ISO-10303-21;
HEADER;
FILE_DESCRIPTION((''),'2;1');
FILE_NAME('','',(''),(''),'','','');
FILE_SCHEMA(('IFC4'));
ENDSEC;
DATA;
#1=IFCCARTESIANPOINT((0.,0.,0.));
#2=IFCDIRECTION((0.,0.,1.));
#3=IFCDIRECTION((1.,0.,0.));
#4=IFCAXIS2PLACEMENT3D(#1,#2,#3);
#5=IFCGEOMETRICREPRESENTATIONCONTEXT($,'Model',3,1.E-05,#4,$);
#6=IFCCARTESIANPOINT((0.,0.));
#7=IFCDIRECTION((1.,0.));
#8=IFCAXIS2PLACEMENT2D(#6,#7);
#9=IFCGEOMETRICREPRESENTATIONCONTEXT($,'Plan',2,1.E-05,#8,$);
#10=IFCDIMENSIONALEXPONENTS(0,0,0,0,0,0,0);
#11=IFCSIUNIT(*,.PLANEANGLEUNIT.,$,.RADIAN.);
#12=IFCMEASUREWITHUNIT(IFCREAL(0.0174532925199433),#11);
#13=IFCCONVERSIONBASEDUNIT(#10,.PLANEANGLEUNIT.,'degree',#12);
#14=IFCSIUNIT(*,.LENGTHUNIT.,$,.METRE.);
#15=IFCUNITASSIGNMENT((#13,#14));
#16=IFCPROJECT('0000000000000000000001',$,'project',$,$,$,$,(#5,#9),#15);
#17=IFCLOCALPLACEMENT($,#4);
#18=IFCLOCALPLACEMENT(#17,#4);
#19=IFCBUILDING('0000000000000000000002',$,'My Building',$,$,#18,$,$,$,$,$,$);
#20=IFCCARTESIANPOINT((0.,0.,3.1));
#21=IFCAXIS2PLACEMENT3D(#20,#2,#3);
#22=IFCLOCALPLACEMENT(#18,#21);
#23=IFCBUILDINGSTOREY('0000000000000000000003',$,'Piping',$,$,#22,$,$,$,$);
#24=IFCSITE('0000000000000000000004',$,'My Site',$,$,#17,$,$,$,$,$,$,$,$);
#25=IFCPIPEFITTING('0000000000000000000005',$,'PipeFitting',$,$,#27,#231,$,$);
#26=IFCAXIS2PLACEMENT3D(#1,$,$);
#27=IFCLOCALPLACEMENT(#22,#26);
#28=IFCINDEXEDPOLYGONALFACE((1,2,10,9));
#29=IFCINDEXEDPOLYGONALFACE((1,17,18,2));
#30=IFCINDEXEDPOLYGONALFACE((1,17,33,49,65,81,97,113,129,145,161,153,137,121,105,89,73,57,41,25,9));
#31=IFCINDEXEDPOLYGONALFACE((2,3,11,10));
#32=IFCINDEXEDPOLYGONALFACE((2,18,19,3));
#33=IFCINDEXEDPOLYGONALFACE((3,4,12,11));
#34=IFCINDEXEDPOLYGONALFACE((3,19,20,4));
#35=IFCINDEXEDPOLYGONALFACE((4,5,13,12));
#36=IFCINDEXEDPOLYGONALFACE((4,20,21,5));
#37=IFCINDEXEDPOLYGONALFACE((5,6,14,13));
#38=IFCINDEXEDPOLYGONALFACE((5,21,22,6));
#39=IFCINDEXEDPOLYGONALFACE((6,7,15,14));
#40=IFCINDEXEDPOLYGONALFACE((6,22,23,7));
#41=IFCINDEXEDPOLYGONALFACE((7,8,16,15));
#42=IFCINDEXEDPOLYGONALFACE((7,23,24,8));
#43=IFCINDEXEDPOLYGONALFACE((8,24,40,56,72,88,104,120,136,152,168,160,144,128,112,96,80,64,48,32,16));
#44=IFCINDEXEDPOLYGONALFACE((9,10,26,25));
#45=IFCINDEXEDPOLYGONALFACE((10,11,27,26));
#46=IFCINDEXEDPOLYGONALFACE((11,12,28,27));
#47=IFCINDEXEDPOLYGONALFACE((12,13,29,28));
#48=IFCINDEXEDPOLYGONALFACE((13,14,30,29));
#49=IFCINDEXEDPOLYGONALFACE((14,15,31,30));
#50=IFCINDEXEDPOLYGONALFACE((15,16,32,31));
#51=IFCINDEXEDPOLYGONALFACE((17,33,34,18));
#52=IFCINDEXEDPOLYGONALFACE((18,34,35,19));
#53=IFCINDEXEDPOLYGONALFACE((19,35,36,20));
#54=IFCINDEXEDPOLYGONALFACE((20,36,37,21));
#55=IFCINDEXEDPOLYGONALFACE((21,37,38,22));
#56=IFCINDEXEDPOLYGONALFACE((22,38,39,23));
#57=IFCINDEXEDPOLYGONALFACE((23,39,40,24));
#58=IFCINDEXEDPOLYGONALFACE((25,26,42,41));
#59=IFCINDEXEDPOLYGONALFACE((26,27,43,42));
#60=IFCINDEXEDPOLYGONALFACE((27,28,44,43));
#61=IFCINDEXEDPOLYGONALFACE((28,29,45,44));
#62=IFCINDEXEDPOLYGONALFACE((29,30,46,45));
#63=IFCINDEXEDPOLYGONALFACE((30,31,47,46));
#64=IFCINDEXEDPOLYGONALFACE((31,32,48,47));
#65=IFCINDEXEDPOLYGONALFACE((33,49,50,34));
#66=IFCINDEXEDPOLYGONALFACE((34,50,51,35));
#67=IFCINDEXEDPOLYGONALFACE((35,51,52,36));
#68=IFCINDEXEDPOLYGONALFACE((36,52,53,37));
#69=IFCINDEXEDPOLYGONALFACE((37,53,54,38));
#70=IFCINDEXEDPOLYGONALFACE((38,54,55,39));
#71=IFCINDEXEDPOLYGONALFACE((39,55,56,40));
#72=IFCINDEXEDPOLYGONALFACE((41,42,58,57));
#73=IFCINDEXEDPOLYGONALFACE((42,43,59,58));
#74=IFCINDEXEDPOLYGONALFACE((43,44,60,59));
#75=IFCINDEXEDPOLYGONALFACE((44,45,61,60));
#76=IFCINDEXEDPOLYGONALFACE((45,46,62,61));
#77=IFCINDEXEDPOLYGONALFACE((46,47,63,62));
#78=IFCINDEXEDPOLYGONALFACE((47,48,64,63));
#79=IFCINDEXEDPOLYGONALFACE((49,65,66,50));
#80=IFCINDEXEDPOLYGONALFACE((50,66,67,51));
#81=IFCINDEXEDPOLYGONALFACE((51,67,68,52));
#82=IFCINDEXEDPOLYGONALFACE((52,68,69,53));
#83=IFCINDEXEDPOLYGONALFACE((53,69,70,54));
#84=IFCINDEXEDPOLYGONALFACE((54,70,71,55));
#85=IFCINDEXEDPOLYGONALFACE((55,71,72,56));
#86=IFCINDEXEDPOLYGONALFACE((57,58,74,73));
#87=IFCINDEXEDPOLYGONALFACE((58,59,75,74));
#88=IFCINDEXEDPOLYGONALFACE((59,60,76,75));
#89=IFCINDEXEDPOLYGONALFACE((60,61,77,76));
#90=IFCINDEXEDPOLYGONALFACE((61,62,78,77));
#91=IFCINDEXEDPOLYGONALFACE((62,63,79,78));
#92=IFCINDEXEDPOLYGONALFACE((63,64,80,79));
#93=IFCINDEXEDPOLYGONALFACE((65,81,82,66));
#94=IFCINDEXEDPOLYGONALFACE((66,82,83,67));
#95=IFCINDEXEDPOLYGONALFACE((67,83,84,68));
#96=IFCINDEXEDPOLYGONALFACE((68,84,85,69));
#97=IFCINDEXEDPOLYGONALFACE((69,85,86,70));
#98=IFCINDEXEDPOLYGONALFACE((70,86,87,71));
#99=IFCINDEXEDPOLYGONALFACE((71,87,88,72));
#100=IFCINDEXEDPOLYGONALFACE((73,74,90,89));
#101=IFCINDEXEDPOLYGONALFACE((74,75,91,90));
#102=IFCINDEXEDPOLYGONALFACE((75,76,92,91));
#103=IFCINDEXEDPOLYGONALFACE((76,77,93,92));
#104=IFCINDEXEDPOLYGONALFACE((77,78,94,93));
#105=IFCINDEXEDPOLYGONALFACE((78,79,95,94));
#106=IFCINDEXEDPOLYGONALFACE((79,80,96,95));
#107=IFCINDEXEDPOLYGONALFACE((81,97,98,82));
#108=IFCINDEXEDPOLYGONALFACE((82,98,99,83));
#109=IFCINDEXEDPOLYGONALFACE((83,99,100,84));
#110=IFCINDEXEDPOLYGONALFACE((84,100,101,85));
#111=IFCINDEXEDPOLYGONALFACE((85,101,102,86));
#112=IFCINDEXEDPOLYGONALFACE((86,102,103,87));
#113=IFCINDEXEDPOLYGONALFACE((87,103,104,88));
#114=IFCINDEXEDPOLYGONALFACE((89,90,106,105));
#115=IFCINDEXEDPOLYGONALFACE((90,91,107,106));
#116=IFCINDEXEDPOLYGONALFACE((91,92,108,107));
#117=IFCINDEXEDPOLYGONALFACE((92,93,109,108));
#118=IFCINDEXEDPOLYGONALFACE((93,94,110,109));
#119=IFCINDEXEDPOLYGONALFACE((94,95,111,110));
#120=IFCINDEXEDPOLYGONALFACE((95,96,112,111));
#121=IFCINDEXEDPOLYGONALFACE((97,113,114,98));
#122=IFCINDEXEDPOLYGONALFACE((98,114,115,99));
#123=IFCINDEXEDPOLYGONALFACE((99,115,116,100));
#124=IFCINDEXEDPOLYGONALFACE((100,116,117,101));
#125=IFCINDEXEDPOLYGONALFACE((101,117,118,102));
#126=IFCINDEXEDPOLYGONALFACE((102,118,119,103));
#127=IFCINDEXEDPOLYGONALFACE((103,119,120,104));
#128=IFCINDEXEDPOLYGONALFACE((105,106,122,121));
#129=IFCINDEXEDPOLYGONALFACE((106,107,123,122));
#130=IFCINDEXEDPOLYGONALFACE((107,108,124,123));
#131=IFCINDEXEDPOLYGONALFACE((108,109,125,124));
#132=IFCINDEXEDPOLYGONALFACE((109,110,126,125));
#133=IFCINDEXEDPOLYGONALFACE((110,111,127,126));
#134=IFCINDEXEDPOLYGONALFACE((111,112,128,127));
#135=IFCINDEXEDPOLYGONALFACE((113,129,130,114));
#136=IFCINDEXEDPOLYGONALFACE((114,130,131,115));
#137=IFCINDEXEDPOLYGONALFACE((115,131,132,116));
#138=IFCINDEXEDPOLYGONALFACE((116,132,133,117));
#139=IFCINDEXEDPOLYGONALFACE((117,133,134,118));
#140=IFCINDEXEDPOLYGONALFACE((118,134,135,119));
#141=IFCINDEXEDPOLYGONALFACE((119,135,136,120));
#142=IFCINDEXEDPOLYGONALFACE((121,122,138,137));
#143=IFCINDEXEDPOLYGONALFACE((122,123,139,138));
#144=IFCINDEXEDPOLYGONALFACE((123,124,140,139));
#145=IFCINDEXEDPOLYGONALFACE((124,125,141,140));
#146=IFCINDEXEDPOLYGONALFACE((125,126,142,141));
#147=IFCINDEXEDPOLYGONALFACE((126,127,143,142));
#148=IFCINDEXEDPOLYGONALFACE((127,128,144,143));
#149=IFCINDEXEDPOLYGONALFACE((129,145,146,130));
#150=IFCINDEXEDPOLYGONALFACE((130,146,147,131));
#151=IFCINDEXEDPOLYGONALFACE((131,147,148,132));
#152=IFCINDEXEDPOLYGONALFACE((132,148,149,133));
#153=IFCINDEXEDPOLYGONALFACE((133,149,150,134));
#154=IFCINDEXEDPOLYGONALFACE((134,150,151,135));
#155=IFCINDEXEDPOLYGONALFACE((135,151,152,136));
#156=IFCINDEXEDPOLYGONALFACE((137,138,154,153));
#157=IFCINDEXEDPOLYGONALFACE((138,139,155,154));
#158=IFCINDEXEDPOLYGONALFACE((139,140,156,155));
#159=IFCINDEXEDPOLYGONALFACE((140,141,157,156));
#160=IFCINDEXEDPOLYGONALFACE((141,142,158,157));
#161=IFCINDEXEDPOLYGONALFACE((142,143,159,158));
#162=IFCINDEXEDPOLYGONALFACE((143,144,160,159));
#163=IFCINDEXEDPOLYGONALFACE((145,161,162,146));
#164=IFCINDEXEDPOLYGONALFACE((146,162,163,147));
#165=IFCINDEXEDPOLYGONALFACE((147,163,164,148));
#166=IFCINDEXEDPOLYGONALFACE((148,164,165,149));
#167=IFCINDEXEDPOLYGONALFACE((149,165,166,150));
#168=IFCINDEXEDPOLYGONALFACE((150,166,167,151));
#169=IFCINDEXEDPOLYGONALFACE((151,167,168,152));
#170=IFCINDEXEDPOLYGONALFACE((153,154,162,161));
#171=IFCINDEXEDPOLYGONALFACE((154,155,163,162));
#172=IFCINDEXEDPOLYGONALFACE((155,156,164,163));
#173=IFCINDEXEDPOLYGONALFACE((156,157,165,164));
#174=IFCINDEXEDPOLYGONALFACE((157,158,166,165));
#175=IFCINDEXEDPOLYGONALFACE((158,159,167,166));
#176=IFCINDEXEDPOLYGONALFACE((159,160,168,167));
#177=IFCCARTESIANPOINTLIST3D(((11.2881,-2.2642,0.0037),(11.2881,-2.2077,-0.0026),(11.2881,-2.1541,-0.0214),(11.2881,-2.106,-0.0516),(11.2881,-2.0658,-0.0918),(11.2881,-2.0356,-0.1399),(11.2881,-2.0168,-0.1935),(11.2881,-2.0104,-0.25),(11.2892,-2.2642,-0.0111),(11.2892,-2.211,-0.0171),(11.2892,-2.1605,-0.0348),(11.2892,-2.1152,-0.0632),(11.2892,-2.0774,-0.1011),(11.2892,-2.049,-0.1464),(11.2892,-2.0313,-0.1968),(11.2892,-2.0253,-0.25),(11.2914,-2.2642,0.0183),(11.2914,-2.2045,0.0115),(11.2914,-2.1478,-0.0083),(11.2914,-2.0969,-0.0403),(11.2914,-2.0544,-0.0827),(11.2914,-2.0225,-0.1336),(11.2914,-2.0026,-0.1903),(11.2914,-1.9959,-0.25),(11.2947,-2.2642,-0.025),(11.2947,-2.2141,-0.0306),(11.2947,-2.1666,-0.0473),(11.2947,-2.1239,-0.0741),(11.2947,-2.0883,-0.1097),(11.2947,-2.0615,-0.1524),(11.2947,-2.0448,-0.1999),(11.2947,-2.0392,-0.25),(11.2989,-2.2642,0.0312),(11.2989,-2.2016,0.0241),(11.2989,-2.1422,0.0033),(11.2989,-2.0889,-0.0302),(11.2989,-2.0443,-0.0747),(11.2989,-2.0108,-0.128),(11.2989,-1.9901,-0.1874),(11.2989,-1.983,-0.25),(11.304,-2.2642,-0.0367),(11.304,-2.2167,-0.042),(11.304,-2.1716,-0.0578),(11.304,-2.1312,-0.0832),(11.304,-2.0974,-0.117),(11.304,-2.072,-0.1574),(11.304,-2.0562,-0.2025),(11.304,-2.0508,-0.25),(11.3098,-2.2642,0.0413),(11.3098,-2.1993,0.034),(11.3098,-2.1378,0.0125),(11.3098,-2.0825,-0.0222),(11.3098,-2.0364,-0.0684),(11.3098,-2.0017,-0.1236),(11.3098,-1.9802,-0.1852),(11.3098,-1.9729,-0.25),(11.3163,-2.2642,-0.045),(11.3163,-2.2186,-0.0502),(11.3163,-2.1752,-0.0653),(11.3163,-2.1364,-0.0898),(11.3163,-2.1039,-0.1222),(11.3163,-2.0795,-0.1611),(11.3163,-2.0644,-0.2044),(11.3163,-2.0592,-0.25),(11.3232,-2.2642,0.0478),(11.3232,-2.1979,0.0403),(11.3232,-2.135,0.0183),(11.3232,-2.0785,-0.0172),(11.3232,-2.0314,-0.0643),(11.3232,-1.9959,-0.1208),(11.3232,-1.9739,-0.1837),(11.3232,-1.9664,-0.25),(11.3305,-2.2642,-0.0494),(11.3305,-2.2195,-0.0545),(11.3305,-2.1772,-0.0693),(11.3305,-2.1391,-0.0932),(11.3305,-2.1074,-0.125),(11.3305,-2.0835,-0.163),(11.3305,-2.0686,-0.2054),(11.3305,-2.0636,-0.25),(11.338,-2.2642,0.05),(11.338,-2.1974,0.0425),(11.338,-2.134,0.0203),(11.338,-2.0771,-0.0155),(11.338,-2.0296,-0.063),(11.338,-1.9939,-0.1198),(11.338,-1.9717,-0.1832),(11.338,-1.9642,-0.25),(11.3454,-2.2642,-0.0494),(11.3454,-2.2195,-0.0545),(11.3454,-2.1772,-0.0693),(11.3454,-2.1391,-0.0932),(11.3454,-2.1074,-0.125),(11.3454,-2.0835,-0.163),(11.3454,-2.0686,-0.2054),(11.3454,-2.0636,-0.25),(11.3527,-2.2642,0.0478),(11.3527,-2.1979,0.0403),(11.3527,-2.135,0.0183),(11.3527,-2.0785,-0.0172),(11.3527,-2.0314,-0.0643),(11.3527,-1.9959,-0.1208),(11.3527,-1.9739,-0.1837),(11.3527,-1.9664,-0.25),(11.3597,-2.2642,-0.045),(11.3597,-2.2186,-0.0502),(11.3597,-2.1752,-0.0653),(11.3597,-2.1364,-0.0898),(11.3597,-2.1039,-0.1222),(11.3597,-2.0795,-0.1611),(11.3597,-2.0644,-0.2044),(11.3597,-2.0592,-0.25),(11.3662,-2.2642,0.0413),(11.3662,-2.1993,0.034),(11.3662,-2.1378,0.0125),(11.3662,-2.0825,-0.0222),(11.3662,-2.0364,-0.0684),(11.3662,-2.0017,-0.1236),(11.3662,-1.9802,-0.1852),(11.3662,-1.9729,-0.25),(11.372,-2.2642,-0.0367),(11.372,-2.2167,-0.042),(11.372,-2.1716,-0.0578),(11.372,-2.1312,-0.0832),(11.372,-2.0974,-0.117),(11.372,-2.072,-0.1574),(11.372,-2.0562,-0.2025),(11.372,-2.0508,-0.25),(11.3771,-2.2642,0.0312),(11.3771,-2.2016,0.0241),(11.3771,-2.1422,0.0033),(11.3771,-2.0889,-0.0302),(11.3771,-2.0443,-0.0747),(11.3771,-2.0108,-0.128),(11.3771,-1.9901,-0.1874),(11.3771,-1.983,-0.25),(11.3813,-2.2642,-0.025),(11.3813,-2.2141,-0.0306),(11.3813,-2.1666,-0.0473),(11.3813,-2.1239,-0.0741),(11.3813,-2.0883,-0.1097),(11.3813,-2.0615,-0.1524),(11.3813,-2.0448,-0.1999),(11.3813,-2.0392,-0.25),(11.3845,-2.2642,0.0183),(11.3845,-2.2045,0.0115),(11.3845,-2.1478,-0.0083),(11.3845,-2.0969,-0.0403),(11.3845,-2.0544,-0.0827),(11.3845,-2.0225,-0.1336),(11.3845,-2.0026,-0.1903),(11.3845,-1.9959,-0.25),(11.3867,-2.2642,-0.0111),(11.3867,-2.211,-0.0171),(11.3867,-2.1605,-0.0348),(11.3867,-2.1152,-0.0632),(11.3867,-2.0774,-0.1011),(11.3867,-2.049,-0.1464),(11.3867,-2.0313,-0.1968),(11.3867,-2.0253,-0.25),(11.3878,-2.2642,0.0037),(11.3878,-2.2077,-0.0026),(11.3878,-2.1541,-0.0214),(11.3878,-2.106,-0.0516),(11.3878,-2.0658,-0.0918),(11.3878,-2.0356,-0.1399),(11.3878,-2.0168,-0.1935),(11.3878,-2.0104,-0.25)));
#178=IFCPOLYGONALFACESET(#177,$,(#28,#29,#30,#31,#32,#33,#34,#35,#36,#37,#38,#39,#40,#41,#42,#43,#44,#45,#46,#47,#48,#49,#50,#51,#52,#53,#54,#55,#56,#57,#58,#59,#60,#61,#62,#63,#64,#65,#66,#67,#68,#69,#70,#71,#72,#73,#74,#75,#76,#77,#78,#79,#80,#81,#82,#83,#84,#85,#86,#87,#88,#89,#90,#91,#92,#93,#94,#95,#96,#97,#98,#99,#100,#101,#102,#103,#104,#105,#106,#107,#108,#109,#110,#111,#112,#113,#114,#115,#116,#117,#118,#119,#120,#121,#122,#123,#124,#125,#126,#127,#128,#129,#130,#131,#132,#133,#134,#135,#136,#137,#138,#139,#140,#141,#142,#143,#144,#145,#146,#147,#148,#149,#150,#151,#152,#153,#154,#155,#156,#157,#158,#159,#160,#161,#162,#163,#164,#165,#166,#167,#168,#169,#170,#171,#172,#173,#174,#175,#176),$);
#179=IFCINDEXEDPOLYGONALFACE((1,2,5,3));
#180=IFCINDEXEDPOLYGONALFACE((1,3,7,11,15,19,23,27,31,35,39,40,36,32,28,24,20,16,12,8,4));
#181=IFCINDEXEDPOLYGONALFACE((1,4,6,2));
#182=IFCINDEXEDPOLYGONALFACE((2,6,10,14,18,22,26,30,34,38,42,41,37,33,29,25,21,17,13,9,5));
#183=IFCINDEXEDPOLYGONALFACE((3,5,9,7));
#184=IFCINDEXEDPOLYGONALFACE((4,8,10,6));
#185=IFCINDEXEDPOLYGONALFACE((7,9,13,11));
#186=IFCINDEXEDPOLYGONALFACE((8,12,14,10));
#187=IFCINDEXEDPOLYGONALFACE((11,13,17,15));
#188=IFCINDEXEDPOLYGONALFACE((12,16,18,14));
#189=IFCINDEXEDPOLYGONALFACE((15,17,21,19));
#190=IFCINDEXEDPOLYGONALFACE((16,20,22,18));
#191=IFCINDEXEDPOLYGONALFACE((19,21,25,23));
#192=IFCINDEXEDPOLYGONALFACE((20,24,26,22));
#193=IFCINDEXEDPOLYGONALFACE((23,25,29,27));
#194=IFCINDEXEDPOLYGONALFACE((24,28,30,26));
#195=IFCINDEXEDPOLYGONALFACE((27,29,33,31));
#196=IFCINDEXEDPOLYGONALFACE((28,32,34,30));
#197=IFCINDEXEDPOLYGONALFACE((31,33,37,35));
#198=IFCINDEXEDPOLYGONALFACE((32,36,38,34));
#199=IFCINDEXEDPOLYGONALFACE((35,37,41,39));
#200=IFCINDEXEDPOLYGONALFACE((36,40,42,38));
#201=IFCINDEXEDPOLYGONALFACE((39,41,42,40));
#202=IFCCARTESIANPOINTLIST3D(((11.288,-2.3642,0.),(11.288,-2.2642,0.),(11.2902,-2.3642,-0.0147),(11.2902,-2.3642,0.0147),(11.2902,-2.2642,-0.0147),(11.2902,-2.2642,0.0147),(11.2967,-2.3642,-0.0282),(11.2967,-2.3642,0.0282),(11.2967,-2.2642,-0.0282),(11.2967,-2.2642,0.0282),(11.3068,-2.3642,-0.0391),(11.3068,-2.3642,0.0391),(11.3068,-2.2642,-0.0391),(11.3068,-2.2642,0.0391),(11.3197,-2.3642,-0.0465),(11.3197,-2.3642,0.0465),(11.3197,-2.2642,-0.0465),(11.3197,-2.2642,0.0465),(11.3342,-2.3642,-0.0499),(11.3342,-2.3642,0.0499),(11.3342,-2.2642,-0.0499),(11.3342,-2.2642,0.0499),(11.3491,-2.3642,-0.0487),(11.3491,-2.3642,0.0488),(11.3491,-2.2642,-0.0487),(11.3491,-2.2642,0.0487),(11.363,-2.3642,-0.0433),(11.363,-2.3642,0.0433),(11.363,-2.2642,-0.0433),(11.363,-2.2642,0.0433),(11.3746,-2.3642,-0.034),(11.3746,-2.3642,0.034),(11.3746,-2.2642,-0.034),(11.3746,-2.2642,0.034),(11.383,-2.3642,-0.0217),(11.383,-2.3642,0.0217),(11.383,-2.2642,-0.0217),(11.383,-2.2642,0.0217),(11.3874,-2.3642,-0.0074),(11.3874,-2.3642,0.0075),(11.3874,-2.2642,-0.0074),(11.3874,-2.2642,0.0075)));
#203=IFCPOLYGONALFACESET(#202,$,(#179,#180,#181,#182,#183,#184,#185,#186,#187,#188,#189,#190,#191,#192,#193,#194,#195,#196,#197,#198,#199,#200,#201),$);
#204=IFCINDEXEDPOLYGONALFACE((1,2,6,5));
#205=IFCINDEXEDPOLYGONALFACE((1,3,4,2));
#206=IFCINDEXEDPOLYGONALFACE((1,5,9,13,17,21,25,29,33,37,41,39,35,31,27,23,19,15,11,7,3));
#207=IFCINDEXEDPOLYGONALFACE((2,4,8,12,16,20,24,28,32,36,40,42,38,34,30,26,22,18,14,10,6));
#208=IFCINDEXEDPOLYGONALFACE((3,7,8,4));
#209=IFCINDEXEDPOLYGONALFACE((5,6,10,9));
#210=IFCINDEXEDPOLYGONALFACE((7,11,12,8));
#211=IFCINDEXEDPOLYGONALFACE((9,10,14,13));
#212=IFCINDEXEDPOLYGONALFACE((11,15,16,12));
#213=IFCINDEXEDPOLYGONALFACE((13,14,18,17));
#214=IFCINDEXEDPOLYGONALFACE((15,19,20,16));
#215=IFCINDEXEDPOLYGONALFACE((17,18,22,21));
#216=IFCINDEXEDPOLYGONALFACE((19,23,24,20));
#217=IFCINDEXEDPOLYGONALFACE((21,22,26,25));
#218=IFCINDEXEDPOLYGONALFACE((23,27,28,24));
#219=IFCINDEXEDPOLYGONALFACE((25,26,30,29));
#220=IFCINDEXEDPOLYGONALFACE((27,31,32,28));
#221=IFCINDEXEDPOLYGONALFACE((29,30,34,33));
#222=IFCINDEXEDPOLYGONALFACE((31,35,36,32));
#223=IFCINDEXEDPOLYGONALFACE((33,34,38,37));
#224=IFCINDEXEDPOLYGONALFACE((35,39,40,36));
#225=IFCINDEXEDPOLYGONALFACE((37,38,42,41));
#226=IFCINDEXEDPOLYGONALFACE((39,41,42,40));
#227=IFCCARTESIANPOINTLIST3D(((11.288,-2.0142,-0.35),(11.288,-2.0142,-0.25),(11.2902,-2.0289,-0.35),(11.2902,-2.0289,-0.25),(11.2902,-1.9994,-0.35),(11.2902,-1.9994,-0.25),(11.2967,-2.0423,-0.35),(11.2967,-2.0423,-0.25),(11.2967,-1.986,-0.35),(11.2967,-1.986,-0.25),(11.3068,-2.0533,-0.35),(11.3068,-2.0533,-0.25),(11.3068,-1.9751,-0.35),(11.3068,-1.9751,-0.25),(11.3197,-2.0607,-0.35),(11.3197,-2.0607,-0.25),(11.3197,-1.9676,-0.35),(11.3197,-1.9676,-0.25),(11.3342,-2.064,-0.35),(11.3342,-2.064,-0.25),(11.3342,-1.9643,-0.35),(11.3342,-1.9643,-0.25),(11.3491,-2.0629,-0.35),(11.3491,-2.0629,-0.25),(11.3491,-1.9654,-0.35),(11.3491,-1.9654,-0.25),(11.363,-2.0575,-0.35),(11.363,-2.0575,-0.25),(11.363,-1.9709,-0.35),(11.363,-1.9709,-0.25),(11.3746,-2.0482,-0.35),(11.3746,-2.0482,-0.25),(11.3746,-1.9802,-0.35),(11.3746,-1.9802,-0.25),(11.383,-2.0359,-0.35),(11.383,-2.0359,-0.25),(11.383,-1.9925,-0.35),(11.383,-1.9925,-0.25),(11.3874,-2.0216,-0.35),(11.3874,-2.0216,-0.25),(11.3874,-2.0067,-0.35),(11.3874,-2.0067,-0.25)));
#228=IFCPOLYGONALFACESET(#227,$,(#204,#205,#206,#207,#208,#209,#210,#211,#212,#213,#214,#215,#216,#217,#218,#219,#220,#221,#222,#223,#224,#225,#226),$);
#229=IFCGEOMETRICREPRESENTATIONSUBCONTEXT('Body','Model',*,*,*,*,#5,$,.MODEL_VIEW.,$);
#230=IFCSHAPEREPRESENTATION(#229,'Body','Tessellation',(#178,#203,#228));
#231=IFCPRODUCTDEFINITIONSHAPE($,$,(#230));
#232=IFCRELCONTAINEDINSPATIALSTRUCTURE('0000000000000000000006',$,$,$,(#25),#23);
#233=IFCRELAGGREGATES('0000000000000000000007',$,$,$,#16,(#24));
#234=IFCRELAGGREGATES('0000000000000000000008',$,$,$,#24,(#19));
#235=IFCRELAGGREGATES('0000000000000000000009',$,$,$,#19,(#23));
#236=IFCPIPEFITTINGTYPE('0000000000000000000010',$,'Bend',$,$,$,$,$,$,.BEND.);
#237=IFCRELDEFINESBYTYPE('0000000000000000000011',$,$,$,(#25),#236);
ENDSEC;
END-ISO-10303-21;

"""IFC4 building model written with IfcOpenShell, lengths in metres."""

from ifc_helpers import new_model, entity, si_unit, converted_unit, frame, origin_with_axes, origin_2d_with_axis, place, context, subcontext, project, spatial, circle, extrude, source, transform, mapped, type_object, type_shapes, element, save


model = new_model("IFC4")

# Units and contexts
model_context = context("Model", 3, precision=1e-05, world=origin_with_axes())
plan_context = context("Plan", 2, precision=1e-05, world=origin_2d_with_axis())
body_context = subcontext(model_context, "Body", "Model", "MODEL_VIEW")
ifc_project = project(units=[converted_unit("PLANEANGLEUNIT", "degree", entity("IfcReal", 0.0174532925199433), si_unit("PLANEANGLEUNIT", "RADIAN"), dimensions=[0, 0, 0, 0, 0, 0, 0]), si_unit("LENGTHUNIT", "METRE")], contexts=[model_context, plan_context])

# Site, building, storey
site_placement = place(None, origin_with_axes())
site = spatial("IfcSite", under=ifc_project, at=site_placement, Name="My Site")
building_placement = place(site_placement, origin_with_axes())
building = spatial("IfcBuilding", under=site, at=building_placement, Name="My Building")
storey_placement = place(building_placement, frame((0.0, 0.0, 3.1), z_axis=(0.0, 0.0, 1.0), x_axis=(1.0, 0.0, 0.0)))
storey = spatial("IfcBuildingStorey", under=building, at=storey_placement, Name="Piping")

# Pipe fitting
pipe_fitting_type_1 = type_object("IfcPipeFittingType", Name="Bend", PredefinedType="BEND")
shared_shape_1 = source(origin_with_axes(), body_context, "Body", "SolidModel", [
    entity("IfcSweptDiskSolid", entity("IfcIndexedPolyCurve", entity("IfcCartesianPointList3D", [[0.0, 0.0, 0.1], [0.0, -0.0732, 0.2768], [0.0, -0.25, 0.35]]), [entity("IfcArcIndex", [1, 2, 3])]), 0.05),
    extrude(circle(Radius=0.05), origin_with_axes(), (0.0, 0.0, 1.0), 0.1),
    extrude(circle(Radius=0.05), frame((0.0, -0.25, 0.35), z_axis=(0.0, -1.0, 0.000022), x_axis=(1.0, 0.0, 0.0)), (0.0, 0.0, 1.0), 0.1),
])
type_shapes(pipe_fitting_type_1, [shared_shape_1])
for number, where, z_axis, x_axis, name in (
    (1, (11.338, -2.3642, 0.0), (0.0, 1.0, -0.000022), (-1.0, 0.0, 0.0), "PipeFitting"),
):
    element("IfcPipeFitting", number, at=place(storey_placement, frame(where, z_axis=z_axis, x_axis=x_axis)), inside=storey, type_object=pipe_fitting_type_1, Name=name, context=body_context, shape_type="MappedRepresentation", body=[
        mapped(shared_shape_1, transform((0.0, 0.0, 0.0), x_axis=(1.0, 0.0, 0.0), y_axis=(0.0, 1.0, 0.0), z_axis=(0.0, 0.0, 1.0), scale=1.0)),
    ])

save(model, "model.ifc")
